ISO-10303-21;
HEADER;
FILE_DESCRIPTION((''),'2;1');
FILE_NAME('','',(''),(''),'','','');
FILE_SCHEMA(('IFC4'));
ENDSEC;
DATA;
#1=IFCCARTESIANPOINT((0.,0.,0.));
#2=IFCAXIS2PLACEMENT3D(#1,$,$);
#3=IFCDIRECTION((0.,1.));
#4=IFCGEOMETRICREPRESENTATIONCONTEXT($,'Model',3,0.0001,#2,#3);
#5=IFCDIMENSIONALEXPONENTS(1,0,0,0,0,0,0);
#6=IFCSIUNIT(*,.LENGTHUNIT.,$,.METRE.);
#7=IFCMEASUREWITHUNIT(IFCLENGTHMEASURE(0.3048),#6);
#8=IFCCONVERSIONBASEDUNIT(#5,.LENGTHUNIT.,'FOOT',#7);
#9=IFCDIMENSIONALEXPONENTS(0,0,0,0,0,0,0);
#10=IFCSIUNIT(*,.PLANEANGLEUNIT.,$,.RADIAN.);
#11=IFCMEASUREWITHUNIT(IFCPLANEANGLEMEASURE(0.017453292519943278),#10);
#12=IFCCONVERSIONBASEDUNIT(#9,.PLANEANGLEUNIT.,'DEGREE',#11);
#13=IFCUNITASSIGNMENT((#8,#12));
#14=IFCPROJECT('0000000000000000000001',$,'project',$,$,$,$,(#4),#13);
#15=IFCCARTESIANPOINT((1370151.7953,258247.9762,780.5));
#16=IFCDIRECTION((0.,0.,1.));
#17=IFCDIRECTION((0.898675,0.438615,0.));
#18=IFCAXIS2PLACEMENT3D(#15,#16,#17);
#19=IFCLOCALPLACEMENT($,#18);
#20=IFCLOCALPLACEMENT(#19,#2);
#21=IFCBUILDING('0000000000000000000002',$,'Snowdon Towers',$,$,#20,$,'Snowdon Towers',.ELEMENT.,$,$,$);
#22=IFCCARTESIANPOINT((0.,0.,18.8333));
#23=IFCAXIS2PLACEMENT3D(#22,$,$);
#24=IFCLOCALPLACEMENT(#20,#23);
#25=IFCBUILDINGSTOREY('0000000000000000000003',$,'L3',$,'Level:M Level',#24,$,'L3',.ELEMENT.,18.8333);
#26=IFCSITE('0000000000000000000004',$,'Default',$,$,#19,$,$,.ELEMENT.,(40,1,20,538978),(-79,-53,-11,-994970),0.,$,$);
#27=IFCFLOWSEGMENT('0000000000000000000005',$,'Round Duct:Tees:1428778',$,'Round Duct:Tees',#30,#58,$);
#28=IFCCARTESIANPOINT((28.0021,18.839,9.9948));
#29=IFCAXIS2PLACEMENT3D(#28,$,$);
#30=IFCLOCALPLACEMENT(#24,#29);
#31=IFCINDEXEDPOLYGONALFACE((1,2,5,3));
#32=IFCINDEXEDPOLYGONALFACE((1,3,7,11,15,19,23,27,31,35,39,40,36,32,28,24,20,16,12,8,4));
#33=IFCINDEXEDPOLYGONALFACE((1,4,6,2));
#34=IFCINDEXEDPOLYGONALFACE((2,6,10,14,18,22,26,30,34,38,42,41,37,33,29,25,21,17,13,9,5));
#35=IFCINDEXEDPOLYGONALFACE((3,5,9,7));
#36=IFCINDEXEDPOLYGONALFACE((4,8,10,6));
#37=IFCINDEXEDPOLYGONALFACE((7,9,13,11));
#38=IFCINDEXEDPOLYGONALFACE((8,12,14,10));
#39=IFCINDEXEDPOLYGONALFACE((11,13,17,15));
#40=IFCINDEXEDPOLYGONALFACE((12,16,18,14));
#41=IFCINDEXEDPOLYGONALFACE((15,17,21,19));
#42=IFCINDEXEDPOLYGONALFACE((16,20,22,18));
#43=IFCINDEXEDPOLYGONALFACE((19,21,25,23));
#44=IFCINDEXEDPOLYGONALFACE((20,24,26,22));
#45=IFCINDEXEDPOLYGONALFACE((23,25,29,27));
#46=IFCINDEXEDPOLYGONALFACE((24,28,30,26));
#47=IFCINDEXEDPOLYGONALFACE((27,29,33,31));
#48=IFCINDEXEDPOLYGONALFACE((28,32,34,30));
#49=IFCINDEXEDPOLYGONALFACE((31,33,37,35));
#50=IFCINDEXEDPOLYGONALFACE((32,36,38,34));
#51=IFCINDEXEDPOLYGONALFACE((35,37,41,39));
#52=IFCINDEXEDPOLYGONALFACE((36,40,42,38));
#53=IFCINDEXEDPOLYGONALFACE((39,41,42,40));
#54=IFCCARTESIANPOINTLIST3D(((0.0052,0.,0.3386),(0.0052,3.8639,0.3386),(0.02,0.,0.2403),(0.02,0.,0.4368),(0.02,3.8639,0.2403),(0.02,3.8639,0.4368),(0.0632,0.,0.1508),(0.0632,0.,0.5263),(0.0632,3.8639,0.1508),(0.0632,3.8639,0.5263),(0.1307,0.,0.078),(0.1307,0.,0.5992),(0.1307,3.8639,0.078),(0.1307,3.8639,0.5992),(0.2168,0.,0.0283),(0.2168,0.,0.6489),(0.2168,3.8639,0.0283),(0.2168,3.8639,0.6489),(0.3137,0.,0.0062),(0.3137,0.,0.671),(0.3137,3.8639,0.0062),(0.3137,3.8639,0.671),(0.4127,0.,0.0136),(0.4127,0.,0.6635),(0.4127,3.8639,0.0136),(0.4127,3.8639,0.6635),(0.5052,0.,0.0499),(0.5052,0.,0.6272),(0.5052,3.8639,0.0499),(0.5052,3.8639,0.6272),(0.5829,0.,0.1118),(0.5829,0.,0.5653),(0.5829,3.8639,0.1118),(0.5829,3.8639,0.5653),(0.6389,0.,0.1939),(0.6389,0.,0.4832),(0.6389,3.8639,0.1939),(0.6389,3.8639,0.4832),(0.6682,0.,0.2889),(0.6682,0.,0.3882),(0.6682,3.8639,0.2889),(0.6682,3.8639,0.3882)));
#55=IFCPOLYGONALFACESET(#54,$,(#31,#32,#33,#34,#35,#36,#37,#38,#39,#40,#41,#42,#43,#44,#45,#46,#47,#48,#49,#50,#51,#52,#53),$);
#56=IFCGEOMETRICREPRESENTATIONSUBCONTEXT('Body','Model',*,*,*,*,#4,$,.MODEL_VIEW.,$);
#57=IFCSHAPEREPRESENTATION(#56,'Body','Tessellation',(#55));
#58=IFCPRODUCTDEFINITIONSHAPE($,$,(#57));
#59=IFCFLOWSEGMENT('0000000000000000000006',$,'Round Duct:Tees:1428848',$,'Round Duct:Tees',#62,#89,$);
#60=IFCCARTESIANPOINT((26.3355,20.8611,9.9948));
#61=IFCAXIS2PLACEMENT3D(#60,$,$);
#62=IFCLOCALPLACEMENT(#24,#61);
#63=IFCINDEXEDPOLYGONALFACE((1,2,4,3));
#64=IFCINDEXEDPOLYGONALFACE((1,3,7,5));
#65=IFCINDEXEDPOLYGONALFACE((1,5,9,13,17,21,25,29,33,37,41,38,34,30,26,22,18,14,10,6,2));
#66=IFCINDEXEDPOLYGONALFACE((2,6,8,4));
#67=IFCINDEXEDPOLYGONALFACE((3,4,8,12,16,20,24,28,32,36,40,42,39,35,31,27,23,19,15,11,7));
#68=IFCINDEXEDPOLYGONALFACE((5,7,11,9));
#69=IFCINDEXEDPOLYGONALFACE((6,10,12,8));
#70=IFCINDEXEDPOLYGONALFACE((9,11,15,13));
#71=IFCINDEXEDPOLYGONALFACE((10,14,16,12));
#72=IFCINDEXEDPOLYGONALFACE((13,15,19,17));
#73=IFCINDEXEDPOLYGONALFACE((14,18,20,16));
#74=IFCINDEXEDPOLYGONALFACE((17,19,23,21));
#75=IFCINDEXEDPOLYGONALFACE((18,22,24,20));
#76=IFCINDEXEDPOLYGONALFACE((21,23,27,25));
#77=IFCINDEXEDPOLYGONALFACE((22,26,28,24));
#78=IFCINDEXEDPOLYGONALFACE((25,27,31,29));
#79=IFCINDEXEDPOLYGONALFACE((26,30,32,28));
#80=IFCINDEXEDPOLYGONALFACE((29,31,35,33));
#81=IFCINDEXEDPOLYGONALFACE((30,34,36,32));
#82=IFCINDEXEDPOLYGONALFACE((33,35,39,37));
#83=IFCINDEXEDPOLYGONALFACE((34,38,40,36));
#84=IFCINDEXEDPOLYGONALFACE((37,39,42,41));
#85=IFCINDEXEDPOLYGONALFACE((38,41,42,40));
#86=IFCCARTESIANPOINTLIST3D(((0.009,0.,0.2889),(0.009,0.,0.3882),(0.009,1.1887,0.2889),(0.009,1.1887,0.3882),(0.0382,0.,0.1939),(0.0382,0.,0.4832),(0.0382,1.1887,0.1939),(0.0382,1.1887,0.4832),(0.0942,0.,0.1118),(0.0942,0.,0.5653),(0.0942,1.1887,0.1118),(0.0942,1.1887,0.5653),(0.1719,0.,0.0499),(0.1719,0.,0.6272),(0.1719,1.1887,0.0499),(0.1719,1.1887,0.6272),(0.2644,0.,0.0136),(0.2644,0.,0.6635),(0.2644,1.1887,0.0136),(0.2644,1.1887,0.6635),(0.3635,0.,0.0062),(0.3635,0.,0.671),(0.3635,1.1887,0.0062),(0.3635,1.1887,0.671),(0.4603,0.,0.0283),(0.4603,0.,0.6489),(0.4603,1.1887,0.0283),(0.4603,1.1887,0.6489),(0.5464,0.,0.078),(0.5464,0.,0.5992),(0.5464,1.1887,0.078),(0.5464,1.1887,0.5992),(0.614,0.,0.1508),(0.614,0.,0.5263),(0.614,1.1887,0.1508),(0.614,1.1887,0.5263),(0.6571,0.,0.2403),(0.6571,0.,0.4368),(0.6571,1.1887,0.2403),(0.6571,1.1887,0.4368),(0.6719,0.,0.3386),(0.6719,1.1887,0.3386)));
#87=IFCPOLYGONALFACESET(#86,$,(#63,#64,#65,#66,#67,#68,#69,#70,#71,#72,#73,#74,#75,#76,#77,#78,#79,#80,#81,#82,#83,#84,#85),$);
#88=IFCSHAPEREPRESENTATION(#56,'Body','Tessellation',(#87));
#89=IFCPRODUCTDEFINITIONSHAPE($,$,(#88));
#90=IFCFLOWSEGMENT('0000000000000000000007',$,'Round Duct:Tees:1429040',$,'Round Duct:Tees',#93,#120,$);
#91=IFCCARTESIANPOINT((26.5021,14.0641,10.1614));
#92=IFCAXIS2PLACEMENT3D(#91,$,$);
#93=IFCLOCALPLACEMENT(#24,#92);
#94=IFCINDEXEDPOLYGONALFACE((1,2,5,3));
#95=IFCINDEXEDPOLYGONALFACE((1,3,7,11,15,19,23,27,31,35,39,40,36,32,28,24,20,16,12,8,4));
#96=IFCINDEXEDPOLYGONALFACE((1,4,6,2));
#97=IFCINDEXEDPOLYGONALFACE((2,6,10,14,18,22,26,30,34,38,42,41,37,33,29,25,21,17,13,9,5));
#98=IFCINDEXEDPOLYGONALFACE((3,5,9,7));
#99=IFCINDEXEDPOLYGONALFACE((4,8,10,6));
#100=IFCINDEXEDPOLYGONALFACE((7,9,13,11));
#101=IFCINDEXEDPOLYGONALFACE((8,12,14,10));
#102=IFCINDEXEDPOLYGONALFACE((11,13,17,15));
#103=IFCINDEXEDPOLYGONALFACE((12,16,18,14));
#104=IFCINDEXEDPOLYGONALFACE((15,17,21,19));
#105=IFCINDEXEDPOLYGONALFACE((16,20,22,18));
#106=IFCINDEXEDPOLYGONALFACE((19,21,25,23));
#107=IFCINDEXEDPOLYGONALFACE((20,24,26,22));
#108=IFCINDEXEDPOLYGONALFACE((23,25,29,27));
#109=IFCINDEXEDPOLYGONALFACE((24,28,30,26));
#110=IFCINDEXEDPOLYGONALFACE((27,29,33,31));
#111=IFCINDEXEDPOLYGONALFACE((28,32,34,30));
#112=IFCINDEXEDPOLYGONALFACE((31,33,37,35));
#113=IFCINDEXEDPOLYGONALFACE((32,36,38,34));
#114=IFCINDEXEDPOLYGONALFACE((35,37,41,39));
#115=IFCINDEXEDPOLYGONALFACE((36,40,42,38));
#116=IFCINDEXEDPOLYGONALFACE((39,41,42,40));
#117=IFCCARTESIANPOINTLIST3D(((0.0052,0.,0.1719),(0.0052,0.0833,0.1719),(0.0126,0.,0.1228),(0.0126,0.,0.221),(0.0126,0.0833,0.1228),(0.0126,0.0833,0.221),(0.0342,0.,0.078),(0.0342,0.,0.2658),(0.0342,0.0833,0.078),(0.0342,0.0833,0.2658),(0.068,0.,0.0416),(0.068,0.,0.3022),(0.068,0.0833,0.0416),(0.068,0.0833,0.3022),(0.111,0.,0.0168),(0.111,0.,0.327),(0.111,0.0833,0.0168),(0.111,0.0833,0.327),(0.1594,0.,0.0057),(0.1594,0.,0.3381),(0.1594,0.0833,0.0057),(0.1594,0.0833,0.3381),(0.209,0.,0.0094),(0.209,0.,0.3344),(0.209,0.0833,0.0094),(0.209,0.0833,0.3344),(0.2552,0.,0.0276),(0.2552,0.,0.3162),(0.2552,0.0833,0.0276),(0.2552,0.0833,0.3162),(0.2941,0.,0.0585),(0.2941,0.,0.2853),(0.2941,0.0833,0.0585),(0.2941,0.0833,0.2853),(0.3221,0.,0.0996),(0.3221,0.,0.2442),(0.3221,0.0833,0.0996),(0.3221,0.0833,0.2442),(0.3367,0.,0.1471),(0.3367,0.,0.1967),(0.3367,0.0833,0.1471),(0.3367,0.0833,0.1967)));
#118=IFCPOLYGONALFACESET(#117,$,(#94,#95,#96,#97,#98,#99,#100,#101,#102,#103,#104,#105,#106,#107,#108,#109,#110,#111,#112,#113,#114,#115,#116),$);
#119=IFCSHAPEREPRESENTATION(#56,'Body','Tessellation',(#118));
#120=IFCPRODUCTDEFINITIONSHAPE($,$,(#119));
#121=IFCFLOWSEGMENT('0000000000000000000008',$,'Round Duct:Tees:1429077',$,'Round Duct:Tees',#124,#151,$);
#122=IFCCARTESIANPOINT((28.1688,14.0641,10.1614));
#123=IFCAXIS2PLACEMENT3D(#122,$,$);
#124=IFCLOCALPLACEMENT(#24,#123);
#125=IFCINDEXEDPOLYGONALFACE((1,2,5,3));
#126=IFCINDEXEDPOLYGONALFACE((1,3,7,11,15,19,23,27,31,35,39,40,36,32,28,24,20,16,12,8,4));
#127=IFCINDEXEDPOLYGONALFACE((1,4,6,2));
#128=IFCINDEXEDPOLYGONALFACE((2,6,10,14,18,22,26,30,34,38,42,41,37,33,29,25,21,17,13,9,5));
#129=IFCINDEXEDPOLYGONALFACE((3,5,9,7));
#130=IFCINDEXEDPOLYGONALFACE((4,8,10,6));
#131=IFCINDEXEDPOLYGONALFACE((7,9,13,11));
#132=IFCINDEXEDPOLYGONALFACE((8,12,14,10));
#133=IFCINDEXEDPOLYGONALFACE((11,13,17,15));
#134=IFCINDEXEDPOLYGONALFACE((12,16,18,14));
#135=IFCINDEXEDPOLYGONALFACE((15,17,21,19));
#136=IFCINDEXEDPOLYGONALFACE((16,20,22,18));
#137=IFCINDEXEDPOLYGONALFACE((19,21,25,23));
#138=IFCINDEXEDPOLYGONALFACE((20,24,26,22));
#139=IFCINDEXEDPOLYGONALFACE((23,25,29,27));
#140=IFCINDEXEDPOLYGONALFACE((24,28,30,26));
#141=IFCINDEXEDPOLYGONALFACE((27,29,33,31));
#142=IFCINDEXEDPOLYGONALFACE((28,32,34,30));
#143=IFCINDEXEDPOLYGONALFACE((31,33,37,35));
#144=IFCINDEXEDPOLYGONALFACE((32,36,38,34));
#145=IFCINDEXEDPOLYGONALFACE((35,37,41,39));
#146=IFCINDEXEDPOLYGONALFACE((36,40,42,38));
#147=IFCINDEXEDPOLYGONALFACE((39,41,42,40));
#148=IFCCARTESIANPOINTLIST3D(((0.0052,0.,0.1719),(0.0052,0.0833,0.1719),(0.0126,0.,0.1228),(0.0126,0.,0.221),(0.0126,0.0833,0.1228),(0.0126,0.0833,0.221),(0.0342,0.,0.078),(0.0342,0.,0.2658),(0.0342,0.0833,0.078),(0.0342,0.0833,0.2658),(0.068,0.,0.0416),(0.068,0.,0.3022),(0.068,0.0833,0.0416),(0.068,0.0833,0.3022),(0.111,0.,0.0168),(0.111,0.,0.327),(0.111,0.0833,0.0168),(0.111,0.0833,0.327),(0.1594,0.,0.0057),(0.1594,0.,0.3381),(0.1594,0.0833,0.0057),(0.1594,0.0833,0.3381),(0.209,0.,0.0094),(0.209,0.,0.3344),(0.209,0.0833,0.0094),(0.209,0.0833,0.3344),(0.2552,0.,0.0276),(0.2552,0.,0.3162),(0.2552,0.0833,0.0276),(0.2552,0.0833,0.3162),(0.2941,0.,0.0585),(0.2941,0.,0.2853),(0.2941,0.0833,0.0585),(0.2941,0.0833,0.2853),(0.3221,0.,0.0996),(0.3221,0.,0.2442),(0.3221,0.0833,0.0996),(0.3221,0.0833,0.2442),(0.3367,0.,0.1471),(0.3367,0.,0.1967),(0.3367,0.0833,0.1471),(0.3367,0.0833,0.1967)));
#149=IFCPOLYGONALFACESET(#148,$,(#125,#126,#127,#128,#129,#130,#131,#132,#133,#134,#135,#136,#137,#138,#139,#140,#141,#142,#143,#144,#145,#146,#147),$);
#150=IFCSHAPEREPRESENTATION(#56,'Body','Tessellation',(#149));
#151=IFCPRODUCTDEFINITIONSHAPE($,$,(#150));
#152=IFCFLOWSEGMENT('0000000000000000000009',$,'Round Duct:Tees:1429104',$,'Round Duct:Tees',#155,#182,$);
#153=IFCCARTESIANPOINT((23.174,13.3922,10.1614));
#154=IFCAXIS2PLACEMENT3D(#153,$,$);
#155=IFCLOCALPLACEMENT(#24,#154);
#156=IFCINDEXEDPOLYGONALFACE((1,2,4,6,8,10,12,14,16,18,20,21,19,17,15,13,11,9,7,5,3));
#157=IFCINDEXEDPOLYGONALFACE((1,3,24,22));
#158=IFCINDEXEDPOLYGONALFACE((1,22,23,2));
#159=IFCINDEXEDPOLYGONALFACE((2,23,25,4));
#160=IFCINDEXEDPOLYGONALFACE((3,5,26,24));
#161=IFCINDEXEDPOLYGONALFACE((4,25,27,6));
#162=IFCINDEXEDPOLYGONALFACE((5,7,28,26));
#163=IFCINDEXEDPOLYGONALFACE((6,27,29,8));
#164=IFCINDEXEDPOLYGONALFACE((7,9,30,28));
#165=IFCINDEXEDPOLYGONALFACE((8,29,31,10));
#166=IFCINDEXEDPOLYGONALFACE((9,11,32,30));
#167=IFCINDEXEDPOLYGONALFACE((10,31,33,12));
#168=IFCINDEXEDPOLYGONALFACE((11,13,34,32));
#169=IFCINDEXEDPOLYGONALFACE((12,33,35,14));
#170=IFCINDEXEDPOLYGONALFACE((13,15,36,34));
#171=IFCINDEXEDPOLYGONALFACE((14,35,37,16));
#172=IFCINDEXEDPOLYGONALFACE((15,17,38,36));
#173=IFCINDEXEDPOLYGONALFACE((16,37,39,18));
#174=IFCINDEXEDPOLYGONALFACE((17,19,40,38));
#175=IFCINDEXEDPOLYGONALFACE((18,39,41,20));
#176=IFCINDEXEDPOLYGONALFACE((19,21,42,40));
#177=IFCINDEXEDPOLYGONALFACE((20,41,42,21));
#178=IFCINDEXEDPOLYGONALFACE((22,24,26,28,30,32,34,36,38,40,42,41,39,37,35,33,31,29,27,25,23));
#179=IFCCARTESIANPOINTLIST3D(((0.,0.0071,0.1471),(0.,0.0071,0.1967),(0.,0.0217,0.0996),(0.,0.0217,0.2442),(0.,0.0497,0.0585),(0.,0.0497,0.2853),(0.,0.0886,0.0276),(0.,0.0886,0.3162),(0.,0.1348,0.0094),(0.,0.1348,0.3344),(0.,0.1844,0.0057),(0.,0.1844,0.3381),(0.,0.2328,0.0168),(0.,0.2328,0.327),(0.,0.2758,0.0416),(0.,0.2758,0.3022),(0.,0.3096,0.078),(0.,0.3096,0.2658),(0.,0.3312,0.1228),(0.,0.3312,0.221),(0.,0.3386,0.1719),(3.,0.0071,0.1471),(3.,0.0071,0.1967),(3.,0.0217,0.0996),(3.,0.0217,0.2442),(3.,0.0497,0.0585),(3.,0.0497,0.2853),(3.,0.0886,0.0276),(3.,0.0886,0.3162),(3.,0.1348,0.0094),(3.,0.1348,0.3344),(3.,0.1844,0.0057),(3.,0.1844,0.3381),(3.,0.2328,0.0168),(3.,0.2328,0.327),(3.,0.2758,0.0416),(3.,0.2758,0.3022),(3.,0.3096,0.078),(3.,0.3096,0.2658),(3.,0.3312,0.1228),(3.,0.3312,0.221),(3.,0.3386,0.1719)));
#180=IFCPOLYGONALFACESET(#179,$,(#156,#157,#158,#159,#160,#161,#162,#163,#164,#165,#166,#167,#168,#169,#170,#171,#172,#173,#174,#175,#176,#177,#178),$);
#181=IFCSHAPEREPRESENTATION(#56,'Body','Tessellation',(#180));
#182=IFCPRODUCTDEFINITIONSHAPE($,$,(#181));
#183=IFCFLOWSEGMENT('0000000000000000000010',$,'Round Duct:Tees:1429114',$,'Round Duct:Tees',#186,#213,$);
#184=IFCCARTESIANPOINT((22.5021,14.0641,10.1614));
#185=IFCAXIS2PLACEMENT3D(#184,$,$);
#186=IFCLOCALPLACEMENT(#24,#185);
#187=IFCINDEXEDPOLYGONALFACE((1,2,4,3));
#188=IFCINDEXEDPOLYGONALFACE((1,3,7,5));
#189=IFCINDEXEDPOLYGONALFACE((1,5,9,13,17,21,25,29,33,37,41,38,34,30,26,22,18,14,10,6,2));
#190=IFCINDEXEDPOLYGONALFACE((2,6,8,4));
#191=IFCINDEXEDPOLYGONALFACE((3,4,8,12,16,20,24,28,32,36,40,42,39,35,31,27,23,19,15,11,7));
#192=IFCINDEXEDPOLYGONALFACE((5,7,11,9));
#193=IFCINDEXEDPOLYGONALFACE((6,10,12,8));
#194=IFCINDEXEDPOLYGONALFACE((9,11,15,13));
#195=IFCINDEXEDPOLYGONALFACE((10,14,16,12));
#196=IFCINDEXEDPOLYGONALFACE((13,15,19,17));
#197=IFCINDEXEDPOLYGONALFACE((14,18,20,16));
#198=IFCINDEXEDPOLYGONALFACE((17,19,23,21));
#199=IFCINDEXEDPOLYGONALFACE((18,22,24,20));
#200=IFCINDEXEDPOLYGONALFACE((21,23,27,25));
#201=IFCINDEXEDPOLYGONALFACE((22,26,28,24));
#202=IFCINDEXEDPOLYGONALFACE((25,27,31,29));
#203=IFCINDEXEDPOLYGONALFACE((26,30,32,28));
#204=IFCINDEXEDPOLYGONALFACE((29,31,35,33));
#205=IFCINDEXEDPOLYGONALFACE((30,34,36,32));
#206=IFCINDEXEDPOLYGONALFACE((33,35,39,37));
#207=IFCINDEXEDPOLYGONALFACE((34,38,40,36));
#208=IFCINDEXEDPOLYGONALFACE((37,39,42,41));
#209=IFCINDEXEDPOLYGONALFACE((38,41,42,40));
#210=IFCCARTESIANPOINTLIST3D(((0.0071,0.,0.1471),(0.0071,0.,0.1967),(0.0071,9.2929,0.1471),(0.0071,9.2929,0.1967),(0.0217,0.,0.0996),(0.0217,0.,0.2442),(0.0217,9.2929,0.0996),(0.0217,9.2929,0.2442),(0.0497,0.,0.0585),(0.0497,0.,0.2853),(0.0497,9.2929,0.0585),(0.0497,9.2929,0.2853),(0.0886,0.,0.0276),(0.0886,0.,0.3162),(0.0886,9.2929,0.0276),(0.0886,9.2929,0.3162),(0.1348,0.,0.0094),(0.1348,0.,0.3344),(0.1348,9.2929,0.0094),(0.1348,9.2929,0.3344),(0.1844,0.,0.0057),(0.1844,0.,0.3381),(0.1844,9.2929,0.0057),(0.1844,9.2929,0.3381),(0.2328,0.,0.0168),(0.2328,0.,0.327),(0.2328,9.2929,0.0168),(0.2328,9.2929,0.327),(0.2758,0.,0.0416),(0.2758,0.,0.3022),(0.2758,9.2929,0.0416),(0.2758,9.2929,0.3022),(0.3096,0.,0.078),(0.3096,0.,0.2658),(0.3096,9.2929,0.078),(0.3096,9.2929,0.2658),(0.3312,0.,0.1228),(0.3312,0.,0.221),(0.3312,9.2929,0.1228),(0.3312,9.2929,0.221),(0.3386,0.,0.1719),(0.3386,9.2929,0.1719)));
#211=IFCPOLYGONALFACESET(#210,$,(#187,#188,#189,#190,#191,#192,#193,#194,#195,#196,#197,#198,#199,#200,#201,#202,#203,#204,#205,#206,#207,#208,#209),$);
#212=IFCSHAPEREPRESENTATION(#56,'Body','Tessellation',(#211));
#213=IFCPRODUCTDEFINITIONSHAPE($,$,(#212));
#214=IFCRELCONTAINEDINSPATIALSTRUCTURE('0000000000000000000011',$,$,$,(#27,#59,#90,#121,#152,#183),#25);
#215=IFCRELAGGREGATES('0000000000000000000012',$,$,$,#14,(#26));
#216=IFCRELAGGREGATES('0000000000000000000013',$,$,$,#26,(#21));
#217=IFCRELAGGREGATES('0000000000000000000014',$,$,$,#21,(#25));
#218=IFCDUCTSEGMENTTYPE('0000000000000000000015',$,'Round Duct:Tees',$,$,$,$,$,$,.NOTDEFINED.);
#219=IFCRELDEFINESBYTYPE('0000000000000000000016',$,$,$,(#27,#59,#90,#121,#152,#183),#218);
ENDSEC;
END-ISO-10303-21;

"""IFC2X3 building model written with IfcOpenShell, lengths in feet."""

from ifc_helpers import new_model, entity, si_unit, converted_unit, direction, frame, frame_2d, origin, place, context, subcontext, project, spatial, circle, extrude, type_object, element, save


model = new_model("IFC2X3")

# Units and contexts
model_context = context("Model", 3, precision=0.0001, world=origin(), true_north=direction((0.0, 1.0)))
body_context = subcontext(model_context, "Body", "Model", "MODEL_VIEW")
ifc_project = project(units=[converted_unit("LENGTHUNIT", "FOOT", entity("IfcLengthMeasure", 0.3048), si_unit("LENGTHUNIT", "METRE"), dimensions=[1, 0, 0, 0, 0, 0, 0]), converted_unit("PLANEANGLEUNIT", "DEGREE", entity("IfcPlaneAngleMeasure", 0.017453292519943278), si_unit("PLANEANGLEUNIT", "RADIAN"), dimensions=[0, 0, 0, 0, 0, 0, 0])], contexts=[model_context])

# Site, building, storey
site_placement = place(None, frame((1370151.7953, 258247.9762, 780.5), z_axis=(0.0, 0.0, 1.0), x_axis=(0.898675, 0.438615, 0.0)))
site = spatial("IfcSite", under=ifc_project, at=site_placement, Name="Default", CompositionType="ELEMENT", RefLatitude=(40, 1, 20, 538978), RefLongitude=(-79, -53, -11, -994970), RefElevation=0.0)
building_placement = place(site_placement, origin())
building = spatial("IfcBuilding", under=site, at=building_placement, Name="Snowdon Towers", LongName="Snowdon Towers", CompositionType="ELEMENT")
storey_placement = place(building_placement, frame((0.0, 0.0, 18.8333)))
storey = spatial("IfcBuildingStorey", under=building, at=storey_placement, Name="L3", ObjectType="Level:M Level", LongName="L3", CompositionType="ELEMENT", Elevation=18.8333)

# Flow segments
duct_segment_type = type_object("IfcDuctSegmentType", Name="Round Duct:Tees", PredefinedType="NOTDEFINED")
flow_segment_1_placement = place(storey_placement, frame((28.0021, 18.839, 9.9948)))
element("IfcFlowSegment", 1, at=flow_segment_1_placement, inside=storey, type_object=duct_segment_type, Name="Round Duct:Tees:1428778", ObjectType="Round Duct:Tees", context=body_context, shape_type="SweptSolid", body=[
    extrude(circle(Radius=0.3333, at=frame_2d((0.0, 0.0), x_axis=(1.0, 0.0))), frame((0.3386, 0.0, 0.3386), z_axis=(0.0, 1.0, 0.0), x_axis=(-1.0, 0.0, 0.0)), (0.0, 0.0, 1.0), 3.8639),
])
flow_segment_2_placement = place(storey_placement, frame((26.3355, 20.8611, 9.9948)))
element("IfcFlowSegment", 2, at=flow_segment_2_placement, inside=storey, type_object=duct_segment_type, Name="Round Duct:Tees:1428848", ObjectType="Round Duct:Tees", context=body_context, shape_type="SweptSolid", body=[
    extrude(circle(Radius=0.3333, at=frame_2d((0.0, 0.0), x_axis=(1.0, 0.0))), frame((0.3386, 0.0, 0.3386), z_axis=(0.0, 1.0, 0.0), x_axis=(1.0, 0.0, 0.0)), (0.0, 0.0, 1.0), 1.1887),
])
flow_segment_3_placement = place(storey_placement, frame((26.5021, 14.0641, 10.1614)))
element("IfcFlowSegment", 3, at=flow_segment_3_placement, inside=storey, type_object=duct_segment_type, Name="Round Duct:Tees:1429040", ObjectType="Round Duct:Tees", context=body_context, shape_type="SweptSolid", body=[
    extrude(circle(Radius=0.1667, at=frame_2d((0.0, 0.0), x_axis=(1.0, 0.0))), frame((0.1719, 0.0, 0.1719), z_axis=(0.0, 1.0, 0.0), x_axis=(-1.0, 0.0, 0.0)), (0.0, 0.0, 1.0), 0.0833),
])
flow_segment_4_placement = place(storey_placement, frame((28.1688, 14.0641, 10.1614)))
element("IfcFlowSegment", 4, at=flow_segment_4_placement, inside=storey, type_object=duct_segment_type, Name="Round Duct:Tees:1429077", ObjectType="Round Duct:Tees", context=body_context, shape_type="SweptSolid", body=[
    extrude(circle(Radius=0.1667, at=frame_2d((0.0, 0.0), x_axis=(1.0, 0.0))), frame((0.1719, 0.0, 0.1719), z_axis=(0.0, 1.0, 0.0), x_axis=(-1.0, 0.0, 0.0)), (0.0, 0.0, 1.0), 0.0833),
])
flow_segment_5_placement = place(storey_placement, frame((23.174, 13.3922, 10.1614)))
element("IfcFlowSegment", 5, at=flow_segment_5_placement, inside=storey, type_object=duct_segment_type, Name="Round Duct:Tees:1429104", ObjectType="Round Duct:Tees", context=body_context, shape_type="SweptSolid", body=[
    extrude(circle(Radius=0.1667, at=frame_2d((0.0, 0.0), x_axis=(1.0, 0.0))), frame((0.0, 0.1719, 0.1719), z_axis=(1.0, 0.0, 0.0), x_axis=(0.0, 1.0, 0.0)), (0.0, 0.0, 1.0), 3.0),
])
flow_segment_6_placement = place(storey_placement, frame((22.5021, 14.0641, 10.1614)))
element("IfcFlowSegment", 6, at=flow_segment_6_placement, inside=storey, type_object=duct_segment_type, Name="Round Duct:Tees:1429114", ObjectType="Round Duct:Tees", context=body_context, shape_type="SweptSolid", body=[
    extrude(circle(Radius=0.1667, at=frame_2d((0.0, 0.0), x_axis=(1.0, 0.0))), frame((0.1719, 0.0, 0.1719), z_axis=(0.0, 1.0, 0.0), x_axis=(1.0, 0.0, 0.0)), (0.0, 0.0, 1.0), 9.2929),
])

save(model, "model.ifc")
